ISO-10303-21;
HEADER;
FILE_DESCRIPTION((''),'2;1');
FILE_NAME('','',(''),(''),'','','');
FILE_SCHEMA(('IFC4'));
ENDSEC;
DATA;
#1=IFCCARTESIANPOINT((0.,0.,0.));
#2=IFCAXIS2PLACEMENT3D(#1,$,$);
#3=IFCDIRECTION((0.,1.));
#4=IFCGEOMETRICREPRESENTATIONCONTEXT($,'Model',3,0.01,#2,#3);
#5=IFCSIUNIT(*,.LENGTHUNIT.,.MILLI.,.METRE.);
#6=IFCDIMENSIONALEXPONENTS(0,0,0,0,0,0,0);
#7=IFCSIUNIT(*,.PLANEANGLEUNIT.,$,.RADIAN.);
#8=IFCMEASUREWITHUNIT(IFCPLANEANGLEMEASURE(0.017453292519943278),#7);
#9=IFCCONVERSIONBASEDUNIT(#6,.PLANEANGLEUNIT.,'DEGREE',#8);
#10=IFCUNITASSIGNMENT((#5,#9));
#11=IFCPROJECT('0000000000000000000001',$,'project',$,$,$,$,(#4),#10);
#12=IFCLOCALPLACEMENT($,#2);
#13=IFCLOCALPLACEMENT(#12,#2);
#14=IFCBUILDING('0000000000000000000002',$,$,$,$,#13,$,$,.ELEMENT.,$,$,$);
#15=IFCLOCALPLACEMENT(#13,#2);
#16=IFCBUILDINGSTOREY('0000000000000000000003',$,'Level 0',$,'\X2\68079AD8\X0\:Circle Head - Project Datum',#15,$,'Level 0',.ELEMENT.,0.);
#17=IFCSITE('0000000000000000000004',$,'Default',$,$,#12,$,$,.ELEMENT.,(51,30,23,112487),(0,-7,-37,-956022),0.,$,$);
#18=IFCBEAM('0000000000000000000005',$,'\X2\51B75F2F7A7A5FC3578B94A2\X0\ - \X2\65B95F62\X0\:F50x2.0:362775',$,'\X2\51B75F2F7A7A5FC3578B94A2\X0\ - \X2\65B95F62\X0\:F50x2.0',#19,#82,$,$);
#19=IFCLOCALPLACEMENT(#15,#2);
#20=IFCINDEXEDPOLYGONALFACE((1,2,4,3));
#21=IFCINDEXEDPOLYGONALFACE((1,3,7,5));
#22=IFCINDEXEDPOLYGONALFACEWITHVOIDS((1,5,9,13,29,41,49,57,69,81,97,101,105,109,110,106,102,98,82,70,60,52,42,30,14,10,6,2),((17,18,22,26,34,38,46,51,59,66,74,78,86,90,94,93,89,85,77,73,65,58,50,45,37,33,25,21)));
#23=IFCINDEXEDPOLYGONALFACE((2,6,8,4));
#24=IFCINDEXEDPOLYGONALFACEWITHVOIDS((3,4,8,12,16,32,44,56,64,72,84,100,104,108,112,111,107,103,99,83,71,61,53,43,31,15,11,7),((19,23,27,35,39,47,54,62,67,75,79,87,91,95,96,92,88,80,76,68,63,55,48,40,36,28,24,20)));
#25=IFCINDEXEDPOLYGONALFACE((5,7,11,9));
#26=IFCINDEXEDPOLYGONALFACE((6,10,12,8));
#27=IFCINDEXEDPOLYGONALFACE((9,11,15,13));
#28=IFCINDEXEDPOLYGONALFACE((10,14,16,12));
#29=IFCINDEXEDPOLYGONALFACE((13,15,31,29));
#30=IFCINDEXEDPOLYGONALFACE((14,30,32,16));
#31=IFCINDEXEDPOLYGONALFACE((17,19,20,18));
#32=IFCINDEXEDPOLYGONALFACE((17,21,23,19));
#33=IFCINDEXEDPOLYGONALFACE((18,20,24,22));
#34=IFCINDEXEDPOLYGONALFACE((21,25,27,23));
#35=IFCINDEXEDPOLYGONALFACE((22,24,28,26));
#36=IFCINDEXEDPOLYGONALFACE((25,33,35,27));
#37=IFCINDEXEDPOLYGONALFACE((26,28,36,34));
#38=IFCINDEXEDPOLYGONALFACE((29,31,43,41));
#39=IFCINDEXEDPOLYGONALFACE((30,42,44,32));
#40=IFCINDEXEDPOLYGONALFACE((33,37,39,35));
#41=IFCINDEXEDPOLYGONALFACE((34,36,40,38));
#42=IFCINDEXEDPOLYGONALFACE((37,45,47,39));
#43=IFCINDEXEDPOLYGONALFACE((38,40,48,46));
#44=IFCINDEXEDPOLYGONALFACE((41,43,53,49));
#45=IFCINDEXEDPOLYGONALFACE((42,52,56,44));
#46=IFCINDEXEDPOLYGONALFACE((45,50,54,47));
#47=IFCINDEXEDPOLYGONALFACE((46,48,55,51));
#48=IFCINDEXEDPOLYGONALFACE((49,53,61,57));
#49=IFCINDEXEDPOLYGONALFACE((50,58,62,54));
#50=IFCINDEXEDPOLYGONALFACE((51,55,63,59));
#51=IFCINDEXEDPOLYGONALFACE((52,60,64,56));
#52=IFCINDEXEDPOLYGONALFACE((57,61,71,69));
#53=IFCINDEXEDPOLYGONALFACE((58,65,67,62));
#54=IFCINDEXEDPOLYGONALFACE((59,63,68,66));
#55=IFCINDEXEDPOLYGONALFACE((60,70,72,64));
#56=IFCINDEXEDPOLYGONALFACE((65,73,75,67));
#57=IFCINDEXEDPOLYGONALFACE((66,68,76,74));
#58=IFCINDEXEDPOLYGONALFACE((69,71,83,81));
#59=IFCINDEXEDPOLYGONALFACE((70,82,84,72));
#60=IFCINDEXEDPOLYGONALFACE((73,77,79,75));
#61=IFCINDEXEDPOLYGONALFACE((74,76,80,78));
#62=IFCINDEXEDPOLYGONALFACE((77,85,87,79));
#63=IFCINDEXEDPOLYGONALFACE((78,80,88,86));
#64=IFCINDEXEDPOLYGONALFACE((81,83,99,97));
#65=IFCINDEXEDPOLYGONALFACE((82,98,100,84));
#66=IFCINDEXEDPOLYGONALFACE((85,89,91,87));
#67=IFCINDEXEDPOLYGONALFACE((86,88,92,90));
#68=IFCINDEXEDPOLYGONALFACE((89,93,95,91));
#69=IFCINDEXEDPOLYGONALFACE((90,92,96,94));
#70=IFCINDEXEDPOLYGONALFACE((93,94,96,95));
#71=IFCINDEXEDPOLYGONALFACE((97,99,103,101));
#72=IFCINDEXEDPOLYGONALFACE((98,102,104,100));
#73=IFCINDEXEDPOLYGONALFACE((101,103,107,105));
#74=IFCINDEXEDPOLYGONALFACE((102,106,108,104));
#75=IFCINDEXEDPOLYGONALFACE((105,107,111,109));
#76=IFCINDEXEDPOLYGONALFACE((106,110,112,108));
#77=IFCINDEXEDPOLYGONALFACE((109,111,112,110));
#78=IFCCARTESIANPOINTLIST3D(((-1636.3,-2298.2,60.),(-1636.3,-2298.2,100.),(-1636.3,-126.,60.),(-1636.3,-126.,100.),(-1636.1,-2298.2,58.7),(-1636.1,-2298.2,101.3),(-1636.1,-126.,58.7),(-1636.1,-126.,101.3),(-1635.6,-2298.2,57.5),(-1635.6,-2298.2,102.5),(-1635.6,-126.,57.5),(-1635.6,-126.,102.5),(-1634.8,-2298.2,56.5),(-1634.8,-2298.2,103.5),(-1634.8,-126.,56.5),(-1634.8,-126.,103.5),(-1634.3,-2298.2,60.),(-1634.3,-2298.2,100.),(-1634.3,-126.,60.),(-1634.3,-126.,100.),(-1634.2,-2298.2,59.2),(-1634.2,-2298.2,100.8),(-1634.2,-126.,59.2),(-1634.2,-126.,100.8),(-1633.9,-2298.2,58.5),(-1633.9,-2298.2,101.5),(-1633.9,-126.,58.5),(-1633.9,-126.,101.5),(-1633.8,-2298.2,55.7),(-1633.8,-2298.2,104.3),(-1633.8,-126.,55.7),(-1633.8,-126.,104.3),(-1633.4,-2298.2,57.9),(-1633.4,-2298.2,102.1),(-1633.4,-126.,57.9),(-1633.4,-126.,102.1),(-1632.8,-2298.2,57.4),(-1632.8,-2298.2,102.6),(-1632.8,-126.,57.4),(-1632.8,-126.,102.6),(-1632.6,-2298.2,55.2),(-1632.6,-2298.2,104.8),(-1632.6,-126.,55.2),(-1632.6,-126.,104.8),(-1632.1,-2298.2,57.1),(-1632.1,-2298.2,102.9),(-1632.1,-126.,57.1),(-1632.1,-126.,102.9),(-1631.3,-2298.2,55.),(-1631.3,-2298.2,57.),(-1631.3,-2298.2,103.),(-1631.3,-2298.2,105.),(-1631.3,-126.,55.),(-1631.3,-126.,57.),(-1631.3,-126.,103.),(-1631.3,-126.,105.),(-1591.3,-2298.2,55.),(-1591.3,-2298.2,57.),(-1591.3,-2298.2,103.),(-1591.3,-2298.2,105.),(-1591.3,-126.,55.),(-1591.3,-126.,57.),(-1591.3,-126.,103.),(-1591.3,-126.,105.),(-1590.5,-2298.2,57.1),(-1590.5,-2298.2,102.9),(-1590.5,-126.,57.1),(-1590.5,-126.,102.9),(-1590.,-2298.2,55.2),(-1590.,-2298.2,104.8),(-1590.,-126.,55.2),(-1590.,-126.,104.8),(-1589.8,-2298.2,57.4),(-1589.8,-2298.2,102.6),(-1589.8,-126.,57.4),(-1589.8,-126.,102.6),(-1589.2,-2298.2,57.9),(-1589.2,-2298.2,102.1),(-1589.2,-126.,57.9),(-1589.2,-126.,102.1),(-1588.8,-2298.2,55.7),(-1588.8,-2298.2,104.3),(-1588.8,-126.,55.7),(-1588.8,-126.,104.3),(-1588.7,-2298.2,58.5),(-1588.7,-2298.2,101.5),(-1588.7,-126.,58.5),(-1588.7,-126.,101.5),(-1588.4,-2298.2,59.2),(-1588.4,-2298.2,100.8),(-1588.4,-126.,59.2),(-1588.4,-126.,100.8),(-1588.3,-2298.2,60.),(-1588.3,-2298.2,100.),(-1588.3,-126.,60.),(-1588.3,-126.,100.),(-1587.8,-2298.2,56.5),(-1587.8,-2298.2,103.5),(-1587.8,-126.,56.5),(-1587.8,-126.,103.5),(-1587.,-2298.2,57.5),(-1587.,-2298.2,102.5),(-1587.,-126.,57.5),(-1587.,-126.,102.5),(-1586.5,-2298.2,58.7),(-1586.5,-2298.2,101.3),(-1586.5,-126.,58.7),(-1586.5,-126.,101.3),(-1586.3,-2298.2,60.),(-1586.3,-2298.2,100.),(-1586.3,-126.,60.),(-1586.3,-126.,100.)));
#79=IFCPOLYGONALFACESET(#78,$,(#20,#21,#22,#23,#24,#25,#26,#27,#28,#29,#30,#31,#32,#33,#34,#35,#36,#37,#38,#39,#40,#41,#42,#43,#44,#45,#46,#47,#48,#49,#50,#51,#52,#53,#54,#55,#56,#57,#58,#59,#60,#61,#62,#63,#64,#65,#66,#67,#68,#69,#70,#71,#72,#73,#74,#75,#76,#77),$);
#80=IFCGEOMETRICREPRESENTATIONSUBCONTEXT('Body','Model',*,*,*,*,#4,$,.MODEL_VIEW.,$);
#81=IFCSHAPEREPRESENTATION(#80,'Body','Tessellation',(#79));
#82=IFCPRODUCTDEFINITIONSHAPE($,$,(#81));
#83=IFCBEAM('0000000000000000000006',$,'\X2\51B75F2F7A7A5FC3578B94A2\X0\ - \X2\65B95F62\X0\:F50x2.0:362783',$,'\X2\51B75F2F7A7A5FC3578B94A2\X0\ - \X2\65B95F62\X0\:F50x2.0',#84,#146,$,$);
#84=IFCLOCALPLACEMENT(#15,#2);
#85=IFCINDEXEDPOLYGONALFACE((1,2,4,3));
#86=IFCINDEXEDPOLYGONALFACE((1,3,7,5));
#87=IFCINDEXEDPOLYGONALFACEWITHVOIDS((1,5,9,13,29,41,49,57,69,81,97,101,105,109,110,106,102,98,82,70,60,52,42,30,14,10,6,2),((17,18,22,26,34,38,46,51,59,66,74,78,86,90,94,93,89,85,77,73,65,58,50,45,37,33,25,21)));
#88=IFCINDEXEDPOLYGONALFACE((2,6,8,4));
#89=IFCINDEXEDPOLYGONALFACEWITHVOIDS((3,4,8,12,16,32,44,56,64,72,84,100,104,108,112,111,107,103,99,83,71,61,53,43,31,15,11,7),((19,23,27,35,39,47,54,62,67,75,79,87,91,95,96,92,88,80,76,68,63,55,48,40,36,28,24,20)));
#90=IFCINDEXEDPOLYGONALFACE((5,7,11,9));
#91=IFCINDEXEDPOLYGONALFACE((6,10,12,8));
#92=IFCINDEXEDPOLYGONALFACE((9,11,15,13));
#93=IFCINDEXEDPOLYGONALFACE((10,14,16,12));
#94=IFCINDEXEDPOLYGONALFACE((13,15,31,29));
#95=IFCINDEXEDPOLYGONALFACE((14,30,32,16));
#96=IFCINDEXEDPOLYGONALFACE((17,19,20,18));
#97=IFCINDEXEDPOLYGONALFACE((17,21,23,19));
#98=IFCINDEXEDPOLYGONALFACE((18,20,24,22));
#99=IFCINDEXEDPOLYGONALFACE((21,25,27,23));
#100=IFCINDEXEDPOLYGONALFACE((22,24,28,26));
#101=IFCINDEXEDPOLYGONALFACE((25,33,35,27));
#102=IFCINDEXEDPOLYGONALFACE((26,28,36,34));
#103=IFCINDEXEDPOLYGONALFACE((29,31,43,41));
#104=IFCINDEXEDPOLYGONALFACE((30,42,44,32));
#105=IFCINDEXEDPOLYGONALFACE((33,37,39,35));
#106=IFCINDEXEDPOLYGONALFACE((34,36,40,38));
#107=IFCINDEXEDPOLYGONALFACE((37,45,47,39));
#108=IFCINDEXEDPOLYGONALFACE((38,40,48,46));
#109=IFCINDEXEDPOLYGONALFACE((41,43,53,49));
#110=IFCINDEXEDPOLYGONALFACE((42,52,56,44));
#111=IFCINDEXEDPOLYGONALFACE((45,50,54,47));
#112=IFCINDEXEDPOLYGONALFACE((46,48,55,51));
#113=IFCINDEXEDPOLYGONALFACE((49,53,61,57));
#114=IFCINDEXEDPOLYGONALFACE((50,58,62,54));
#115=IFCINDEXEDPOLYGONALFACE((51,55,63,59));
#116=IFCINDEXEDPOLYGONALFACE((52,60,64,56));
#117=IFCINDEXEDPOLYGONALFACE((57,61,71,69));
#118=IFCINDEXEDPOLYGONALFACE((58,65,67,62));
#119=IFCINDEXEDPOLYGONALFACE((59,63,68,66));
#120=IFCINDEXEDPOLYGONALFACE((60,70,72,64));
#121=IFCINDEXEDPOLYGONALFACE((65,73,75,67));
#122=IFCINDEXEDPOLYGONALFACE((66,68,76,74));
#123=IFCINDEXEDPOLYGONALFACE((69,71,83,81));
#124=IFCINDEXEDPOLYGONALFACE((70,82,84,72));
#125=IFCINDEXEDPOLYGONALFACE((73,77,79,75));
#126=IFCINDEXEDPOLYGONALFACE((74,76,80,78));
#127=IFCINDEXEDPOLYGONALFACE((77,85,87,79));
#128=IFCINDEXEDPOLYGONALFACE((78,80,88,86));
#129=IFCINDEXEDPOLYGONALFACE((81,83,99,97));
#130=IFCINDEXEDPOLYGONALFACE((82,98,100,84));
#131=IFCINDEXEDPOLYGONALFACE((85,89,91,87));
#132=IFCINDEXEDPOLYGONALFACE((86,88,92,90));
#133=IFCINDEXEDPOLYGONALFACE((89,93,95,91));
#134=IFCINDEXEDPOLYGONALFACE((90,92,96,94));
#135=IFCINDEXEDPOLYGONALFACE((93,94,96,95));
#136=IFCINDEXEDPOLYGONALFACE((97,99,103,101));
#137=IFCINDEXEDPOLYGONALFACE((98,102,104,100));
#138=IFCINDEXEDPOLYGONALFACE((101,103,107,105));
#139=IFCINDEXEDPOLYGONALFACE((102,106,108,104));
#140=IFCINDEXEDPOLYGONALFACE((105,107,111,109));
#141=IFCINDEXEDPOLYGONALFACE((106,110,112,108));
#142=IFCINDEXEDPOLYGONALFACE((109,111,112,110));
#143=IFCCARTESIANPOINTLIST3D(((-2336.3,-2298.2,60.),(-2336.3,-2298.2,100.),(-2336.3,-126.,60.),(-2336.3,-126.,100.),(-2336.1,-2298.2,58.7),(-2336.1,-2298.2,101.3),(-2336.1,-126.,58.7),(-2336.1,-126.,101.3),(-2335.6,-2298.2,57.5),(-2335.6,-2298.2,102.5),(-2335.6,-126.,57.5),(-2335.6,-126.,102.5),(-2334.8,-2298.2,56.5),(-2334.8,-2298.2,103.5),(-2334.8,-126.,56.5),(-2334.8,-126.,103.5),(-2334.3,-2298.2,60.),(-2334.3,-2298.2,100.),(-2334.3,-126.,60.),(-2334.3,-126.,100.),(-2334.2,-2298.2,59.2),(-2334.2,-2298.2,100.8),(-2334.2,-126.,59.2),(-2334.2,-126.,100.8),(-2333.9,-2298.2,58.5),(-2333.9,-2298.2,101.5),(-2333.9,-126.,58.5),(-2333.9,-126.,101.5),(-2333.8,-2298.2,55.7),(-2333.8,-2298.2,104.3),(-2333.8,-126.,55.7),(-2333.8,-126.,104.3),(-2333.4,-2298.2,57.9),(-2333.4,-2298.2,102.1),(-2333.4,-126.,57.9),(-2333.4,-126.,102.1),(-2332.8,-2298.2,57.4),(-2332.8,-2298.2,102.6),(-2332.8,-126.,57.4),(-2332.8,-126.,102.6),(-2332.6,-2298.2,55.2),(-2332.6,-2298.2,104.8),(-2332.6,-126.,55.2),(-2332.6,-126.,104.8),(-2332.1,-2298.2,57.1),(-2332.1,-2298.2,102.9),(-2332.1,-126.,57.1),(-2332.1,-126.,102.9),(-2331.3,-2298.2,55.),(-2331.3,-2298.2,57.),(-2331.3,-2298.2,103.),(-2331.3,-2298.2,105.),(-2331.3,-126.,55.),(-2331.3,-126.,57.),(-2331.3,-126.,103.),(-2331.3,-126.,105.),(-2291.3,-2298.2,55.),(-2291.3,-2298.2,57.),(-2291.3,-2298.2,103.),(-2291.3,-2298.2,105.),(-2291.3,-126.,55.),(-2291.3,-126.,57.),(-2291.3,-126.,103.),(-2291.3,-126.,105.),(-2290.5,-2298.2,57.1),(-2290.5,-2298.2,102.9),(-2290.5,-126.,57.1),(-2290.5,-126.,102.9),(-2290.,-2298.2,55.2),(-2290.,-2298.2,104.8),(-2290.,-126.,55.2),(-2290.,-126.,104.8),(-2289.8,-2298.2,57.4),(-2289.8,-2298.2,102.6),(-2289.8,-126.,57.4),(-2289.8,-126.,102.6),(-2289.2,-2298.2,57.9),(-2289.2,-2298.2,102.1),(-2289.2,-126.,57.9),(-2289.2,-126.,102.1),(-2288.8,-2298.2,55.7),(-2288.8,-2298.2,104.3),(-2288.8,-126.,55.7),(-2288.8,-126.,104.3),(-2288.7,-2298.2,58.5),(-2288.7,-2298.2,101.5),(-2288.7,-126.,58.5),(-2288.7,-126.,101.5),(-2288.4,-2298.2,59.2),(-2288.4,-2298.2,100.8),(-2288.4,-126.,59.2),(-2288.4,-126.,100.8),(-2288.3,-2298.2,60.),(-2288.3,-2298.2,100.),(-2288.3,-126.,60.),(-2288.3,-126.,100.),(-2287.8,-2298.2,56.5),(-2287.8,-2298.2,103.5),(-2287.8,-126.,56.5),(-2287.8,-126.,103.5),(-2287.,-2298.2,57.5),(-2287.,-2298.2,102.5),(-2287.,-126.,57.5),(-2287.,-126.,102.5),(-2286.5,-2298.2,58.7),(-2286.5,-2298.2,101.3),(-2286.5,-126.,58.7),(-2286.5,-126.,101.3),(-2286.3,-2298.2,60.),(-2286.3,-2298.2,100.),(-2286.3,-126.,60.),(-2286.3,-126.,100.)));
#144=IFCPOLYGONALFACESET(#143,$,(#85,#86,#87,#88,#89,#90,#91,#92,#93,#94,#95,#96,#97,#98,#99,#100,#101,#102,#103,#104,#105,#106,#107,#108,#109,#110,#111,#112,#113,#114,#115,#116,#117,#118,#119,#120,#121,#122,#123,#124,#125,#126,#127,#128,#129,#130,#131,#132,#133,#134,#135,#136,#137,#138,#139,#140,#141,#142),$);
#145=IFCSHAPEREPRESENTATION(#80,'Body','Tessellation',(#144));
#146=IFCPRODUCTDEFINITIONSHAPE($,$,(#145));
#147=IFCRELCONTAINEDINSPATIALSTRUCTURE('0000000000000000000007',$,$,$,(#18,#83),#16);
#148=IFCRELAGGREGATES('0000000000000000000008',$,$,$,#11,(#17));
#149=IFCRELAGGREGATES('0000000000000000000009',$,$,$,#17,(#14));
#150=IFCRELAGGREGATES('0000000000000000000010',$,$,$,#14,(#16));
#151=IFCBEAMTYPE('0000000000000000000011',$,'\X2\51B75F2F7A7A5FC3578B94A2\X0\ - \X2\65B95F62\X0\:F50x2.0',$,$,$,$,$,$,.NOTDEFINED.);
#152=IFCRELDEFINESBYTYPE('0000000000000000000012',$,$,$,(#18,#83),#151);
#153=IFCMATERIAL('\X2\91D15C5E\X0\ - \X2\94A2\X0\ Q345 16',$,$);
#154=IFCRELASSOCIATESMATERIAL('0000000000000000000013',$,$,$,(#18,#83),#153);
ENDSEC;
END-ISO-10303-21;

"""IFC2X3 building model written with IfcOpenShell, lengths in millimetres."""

from ifc_helpers import new_model, entity, si_unit, converted_unit, direction, frame, frame_2d, origin, place, context, subcontext, project, spatial, polyline, circle_curve, parameter, trimmed, segment, composite_curve, outline, extrude, material, type_object, element, save


model = new_model("IFC2X3")

# Units and contexts
model_context = context("Model", 3, precision=0.01, world=origin(), true_north=direction((0.0, 1.0)))
body_context = subcontext(model_context, "Body", "Model", "MODEL_VIEW")
ifc_project = project(units=[si_unit("LENGTHUNIT", "METRE", prefix="MILLI"), converted_unit("PLANEANGLEUNIT", "DEGREE", entity("IfcPlaneAngleMeasure", 0.017453292519943278), si_unit("PLANEANGLEUNIT", "RADIAN"), dimensions=[0, 0, 0, 0, 0, 0, 0])], contexts=[model_context])

# Site, building, storey
site_placement = place(None, origin())
site = spatial("IfcSite", under=ifc_project, at=site_placement, Name="Default", CompositionType="ELEMENT", RefLatitude=(51, 30, 23, 112487), RefLongitude=(0, -7, -37, -956022), RefElevation=0.0)
building_placement = place(site_placement, origin())
building = spatial("IfcBuilding", under=site, at=building_placement, CompositionType="ELEMENT")
storey_placement = place(building_placement, origin())
storey = spatial("IfcBuildingStorey", under=building, at=storey_placement, Name="Level 0", ObjectType="标高:Circle Head - Project Datum", LongName="Level 0", CompositionType="ELEMENT", Elevation=0.0)

# Beams
ifc_material_1 = material(Name="金属 - 钢 Q345 16")
beam_type_1 = type_object("IfcBeamType", Name="冷弯空心型钢 - 方形:F50x2.0", PredefinedType="NOTDEFINED")
beam_1_placement = place(storey_placement, frame((-1611.3, -390.5, 105.0), z_axis=(0.0, 0.0, 1.0), x_axis=(0.0, -1.0, 0.0)))
element("IfcBeam", 1, at=beam_1_placement, inside=storey, type_object=beam_type_1, material=ifc_material_1, Name="冷弯空心型钢 - 方形:F50x2.0:362775", ObjectType="冷弯空心型钢 - 方形:F50x2.0", context=body_context, shape_type="SweptSolid", body=[
    extrude(outline(composite_curve([segment(trimmed(circle_curve(frame_2d((-20.0, 20.0), x_axis=(1.0, 0.0)), 5.0), [parameter(90.0)], [parameter(180.0)], True, "PARAMETER"), True, "CONTINUOUS"), segment(polyline([(-25.0, 20.0), (-25.0, -20.0)]), True, "CONTINUOUS"), segment(trimmed(circle_curve(frame_2d((-20.0, -20.0), x_axis=(1.0, 0.0)), 5.0), [parameter(180.0)], [parameter(270.0)], True, "PARAMETER"), True, "CONTINUOUS"), segment(polyline([(-20.0, -25.0), (20.0, -25.0)]), True, "CONTINUOUS"), segment(trimmed(circle_curve(frame_2d((20.0, -20.0), x_axis=(1.0, 0.0)), 5.0), [parameter(270.0)], [parameter(0.0)], True, "PARAMETER"), True, "CONTINUOUS"), segment(polyline([(25.0, -20.0), (25.0, 20.0)]), True, "CONTINUOUS"), segment(trimmed(circle_curve(frame_2d((20.0, 20.0), x_axis=(1.0, 0.0)), 5.0), [parameter(0.0)], [parameter(90.0)], True, "PARAMETER"), True, "CONTINUOUS"), segment(polyline([(20.0, 25.0), (-20.0, 25.0)]), True, "CONTINUOUS")], self_intersect=False), holes=[composite_curve([segment(polyline([(-20.0, 23.0), (20.0, 23.0)]), True, "CONTINUOUS"), segment(trimmed(circle_curve(frame_2d((20.0, 20.0), x_axis=(1.0, 0.0)), 3.0), [parameter(360.0)], [parameter(90.0)], True, "PARAMETER"), False, "CONTINUOUS"), segment(polyline([(23.0, 20.0), (23.0, -20.0)]), True, "CONTINUOUS"), segment(trimmed(circle_curve(frame_2d((20.0, -20.0), x_axis=(1.0, 0.0)), 3.0), [parameter(270.0)], [parameter(360.0)], True, "PARAMETER"), False, "CONTINUOUS"), segment(polyline([(20.0, -23.0), (-20.0, -23.0)]), True, "CONTINUOUS"), segment(trimmed(circle_curve(frame_2d((-20.0, -20.0), x_axis=(1.0, 0.0)), 3.0), [parameter(180.0)], [parameter(270.0)], True, "PARAMETER"), False, "CONTINUOUS"), segment(polyline([(-23.0, -20.0), (-23.0, 20.0)]), True, "CONTINUOUS"), segment(trimmed(circle_curve(frame_2d((-20.0, 20.0), x_axis=(1.0, 0.0)), 3.0), [parameter(90.0)], [parameter(180.0)], True, "PARAMETER"), False, "CONTINUOUS")], self_intersect=False)]), frame((-264.5, 0.0, -25.0), z_axis=(1.0, 0.0, 0.0), x_axis=(0.0, 1.0, 0.0)), (0.0, 0.0, 1.0), 2172.2),
])
beam_2_placement = place(storey_placement, frame((-2311.3, -390.5, 105.0), z_axis=(0.0, 0.0, 1.0), x_axis=(0.0, -1.0, 0.0)))
element("IfcBeam", 2, at=beam_2_placement, inside=storey, type_object=beam_type_1, material=ifc_material_1, Name="冷弯空心型钢 - 方形:F50x2.0:362783", ObjectType="冷弯空心型钢 - 方形:F50x2.0", context=body_context, shape_type="SweptSolid", body=[
    extrude(outline(composite_curve([segment(trimmed(circle_curve(frame_2d((-20.0, 20.0), x_axis=(1.0, 0.0)), 5.0), [parameter(90.0)], [parameter(180.0)], True, "PARAMETER"), True, "CONTINUOUS"), segment(polyline([(-25.0, 20.0), (-25.0, -20.0)]), True, "CONTINUOUS"), segment(trimmed(circle_curve(frame_2d((-20.0, -20.0), x_axis=(1.0, 0.0)), 5.0), [parameter(180.0)], [parameter(270.0)], True, "PARAMETER"), True, "CONTINUOUS"), segment(polyline([(-20.0, -25.0), (20.0, -25.0)]), True, "CONTINUOUS"), segment(trimmed(circle_curve(frame_2d((20.0, -20.0), x_axis=(1.0, 0.0)), 5.0), [parameter(270.0)], [parameter(0.0)], True, "PARAMETER"), True, "CONTINUOUS"), segment(polyline([(25.0, -20.0), (25.0, 20.0)]), True, "CONTINUOUS"), segment(trimmed(circle_curve(frame_2d((20.0, 20.0), x_axis=(1.0, 0.0)), 5.0), [parameter(0.0)], [parameter(90.0)], True, "PARAMETER"), True, "CONTINUOUS"), segment(polyline([(20.0, 25.0), (-20.0, 25.0)]), True, "CONTINUOUS")], self_intersect=False), holes=[composite_curve([segment(polyline([(-20.0, 23.0), (20.0, 23.0)]), True, "CONTINUOUS"), segment(trimmed(circle_curve(frame_2d((20.0, 20.0), x_axis=(1.0, 0.0)), 3.0), [parameter(360.0)], [parameter(90.0)], True, "PARAMETER"), False, "CONTINUOUS"), segment(polyline([(23.0, 20.0), (23.0, -20.0)]), True, "CONTINUOUS"), segment(trimmed(circle_curve(frame_2d((20.0, -20.0), x_axis=(1.0, 0.0)), 3.0), [parameter(270.0)], [parameter(360.0)], True, "PARAMETER"), False, "CONTINUOUS"), segment(polyline([(20.0, -23.0), (-20.0, -23.0)]), True, "CONTINUOUS"), segment(trimmed(circle_curve(frame_2d((-20.0, -20.0), x_axis=(1.0, 0.0)), 3.0), [parameter(180.0)], [parameter(270.0)], True, "PARAMETER"), False, "CONTINUOUS"), segment(polyline([(-23.0, -20.0), (-23.0, 20.0)]), True, "CONTINUOUS"), segment(trimmed(circle_curve(frame_2d((-20.0, 20.0), x_axis=(1.0, 0.0)), 3.0), [parameter(90.0)], [parameter(180.0)], True, "PARAMETER"), False, "CONTINUOUS")], self_intersect=False)]), frame((-264.5, 0.0, -25.0), z_axis=(1.0, 0.0, 0.0), x_axis=(0.0, 1.0, 0.0)), (0.0, 0.0, 1.0), 2172.2),
])

save(model, "model.ifc")
